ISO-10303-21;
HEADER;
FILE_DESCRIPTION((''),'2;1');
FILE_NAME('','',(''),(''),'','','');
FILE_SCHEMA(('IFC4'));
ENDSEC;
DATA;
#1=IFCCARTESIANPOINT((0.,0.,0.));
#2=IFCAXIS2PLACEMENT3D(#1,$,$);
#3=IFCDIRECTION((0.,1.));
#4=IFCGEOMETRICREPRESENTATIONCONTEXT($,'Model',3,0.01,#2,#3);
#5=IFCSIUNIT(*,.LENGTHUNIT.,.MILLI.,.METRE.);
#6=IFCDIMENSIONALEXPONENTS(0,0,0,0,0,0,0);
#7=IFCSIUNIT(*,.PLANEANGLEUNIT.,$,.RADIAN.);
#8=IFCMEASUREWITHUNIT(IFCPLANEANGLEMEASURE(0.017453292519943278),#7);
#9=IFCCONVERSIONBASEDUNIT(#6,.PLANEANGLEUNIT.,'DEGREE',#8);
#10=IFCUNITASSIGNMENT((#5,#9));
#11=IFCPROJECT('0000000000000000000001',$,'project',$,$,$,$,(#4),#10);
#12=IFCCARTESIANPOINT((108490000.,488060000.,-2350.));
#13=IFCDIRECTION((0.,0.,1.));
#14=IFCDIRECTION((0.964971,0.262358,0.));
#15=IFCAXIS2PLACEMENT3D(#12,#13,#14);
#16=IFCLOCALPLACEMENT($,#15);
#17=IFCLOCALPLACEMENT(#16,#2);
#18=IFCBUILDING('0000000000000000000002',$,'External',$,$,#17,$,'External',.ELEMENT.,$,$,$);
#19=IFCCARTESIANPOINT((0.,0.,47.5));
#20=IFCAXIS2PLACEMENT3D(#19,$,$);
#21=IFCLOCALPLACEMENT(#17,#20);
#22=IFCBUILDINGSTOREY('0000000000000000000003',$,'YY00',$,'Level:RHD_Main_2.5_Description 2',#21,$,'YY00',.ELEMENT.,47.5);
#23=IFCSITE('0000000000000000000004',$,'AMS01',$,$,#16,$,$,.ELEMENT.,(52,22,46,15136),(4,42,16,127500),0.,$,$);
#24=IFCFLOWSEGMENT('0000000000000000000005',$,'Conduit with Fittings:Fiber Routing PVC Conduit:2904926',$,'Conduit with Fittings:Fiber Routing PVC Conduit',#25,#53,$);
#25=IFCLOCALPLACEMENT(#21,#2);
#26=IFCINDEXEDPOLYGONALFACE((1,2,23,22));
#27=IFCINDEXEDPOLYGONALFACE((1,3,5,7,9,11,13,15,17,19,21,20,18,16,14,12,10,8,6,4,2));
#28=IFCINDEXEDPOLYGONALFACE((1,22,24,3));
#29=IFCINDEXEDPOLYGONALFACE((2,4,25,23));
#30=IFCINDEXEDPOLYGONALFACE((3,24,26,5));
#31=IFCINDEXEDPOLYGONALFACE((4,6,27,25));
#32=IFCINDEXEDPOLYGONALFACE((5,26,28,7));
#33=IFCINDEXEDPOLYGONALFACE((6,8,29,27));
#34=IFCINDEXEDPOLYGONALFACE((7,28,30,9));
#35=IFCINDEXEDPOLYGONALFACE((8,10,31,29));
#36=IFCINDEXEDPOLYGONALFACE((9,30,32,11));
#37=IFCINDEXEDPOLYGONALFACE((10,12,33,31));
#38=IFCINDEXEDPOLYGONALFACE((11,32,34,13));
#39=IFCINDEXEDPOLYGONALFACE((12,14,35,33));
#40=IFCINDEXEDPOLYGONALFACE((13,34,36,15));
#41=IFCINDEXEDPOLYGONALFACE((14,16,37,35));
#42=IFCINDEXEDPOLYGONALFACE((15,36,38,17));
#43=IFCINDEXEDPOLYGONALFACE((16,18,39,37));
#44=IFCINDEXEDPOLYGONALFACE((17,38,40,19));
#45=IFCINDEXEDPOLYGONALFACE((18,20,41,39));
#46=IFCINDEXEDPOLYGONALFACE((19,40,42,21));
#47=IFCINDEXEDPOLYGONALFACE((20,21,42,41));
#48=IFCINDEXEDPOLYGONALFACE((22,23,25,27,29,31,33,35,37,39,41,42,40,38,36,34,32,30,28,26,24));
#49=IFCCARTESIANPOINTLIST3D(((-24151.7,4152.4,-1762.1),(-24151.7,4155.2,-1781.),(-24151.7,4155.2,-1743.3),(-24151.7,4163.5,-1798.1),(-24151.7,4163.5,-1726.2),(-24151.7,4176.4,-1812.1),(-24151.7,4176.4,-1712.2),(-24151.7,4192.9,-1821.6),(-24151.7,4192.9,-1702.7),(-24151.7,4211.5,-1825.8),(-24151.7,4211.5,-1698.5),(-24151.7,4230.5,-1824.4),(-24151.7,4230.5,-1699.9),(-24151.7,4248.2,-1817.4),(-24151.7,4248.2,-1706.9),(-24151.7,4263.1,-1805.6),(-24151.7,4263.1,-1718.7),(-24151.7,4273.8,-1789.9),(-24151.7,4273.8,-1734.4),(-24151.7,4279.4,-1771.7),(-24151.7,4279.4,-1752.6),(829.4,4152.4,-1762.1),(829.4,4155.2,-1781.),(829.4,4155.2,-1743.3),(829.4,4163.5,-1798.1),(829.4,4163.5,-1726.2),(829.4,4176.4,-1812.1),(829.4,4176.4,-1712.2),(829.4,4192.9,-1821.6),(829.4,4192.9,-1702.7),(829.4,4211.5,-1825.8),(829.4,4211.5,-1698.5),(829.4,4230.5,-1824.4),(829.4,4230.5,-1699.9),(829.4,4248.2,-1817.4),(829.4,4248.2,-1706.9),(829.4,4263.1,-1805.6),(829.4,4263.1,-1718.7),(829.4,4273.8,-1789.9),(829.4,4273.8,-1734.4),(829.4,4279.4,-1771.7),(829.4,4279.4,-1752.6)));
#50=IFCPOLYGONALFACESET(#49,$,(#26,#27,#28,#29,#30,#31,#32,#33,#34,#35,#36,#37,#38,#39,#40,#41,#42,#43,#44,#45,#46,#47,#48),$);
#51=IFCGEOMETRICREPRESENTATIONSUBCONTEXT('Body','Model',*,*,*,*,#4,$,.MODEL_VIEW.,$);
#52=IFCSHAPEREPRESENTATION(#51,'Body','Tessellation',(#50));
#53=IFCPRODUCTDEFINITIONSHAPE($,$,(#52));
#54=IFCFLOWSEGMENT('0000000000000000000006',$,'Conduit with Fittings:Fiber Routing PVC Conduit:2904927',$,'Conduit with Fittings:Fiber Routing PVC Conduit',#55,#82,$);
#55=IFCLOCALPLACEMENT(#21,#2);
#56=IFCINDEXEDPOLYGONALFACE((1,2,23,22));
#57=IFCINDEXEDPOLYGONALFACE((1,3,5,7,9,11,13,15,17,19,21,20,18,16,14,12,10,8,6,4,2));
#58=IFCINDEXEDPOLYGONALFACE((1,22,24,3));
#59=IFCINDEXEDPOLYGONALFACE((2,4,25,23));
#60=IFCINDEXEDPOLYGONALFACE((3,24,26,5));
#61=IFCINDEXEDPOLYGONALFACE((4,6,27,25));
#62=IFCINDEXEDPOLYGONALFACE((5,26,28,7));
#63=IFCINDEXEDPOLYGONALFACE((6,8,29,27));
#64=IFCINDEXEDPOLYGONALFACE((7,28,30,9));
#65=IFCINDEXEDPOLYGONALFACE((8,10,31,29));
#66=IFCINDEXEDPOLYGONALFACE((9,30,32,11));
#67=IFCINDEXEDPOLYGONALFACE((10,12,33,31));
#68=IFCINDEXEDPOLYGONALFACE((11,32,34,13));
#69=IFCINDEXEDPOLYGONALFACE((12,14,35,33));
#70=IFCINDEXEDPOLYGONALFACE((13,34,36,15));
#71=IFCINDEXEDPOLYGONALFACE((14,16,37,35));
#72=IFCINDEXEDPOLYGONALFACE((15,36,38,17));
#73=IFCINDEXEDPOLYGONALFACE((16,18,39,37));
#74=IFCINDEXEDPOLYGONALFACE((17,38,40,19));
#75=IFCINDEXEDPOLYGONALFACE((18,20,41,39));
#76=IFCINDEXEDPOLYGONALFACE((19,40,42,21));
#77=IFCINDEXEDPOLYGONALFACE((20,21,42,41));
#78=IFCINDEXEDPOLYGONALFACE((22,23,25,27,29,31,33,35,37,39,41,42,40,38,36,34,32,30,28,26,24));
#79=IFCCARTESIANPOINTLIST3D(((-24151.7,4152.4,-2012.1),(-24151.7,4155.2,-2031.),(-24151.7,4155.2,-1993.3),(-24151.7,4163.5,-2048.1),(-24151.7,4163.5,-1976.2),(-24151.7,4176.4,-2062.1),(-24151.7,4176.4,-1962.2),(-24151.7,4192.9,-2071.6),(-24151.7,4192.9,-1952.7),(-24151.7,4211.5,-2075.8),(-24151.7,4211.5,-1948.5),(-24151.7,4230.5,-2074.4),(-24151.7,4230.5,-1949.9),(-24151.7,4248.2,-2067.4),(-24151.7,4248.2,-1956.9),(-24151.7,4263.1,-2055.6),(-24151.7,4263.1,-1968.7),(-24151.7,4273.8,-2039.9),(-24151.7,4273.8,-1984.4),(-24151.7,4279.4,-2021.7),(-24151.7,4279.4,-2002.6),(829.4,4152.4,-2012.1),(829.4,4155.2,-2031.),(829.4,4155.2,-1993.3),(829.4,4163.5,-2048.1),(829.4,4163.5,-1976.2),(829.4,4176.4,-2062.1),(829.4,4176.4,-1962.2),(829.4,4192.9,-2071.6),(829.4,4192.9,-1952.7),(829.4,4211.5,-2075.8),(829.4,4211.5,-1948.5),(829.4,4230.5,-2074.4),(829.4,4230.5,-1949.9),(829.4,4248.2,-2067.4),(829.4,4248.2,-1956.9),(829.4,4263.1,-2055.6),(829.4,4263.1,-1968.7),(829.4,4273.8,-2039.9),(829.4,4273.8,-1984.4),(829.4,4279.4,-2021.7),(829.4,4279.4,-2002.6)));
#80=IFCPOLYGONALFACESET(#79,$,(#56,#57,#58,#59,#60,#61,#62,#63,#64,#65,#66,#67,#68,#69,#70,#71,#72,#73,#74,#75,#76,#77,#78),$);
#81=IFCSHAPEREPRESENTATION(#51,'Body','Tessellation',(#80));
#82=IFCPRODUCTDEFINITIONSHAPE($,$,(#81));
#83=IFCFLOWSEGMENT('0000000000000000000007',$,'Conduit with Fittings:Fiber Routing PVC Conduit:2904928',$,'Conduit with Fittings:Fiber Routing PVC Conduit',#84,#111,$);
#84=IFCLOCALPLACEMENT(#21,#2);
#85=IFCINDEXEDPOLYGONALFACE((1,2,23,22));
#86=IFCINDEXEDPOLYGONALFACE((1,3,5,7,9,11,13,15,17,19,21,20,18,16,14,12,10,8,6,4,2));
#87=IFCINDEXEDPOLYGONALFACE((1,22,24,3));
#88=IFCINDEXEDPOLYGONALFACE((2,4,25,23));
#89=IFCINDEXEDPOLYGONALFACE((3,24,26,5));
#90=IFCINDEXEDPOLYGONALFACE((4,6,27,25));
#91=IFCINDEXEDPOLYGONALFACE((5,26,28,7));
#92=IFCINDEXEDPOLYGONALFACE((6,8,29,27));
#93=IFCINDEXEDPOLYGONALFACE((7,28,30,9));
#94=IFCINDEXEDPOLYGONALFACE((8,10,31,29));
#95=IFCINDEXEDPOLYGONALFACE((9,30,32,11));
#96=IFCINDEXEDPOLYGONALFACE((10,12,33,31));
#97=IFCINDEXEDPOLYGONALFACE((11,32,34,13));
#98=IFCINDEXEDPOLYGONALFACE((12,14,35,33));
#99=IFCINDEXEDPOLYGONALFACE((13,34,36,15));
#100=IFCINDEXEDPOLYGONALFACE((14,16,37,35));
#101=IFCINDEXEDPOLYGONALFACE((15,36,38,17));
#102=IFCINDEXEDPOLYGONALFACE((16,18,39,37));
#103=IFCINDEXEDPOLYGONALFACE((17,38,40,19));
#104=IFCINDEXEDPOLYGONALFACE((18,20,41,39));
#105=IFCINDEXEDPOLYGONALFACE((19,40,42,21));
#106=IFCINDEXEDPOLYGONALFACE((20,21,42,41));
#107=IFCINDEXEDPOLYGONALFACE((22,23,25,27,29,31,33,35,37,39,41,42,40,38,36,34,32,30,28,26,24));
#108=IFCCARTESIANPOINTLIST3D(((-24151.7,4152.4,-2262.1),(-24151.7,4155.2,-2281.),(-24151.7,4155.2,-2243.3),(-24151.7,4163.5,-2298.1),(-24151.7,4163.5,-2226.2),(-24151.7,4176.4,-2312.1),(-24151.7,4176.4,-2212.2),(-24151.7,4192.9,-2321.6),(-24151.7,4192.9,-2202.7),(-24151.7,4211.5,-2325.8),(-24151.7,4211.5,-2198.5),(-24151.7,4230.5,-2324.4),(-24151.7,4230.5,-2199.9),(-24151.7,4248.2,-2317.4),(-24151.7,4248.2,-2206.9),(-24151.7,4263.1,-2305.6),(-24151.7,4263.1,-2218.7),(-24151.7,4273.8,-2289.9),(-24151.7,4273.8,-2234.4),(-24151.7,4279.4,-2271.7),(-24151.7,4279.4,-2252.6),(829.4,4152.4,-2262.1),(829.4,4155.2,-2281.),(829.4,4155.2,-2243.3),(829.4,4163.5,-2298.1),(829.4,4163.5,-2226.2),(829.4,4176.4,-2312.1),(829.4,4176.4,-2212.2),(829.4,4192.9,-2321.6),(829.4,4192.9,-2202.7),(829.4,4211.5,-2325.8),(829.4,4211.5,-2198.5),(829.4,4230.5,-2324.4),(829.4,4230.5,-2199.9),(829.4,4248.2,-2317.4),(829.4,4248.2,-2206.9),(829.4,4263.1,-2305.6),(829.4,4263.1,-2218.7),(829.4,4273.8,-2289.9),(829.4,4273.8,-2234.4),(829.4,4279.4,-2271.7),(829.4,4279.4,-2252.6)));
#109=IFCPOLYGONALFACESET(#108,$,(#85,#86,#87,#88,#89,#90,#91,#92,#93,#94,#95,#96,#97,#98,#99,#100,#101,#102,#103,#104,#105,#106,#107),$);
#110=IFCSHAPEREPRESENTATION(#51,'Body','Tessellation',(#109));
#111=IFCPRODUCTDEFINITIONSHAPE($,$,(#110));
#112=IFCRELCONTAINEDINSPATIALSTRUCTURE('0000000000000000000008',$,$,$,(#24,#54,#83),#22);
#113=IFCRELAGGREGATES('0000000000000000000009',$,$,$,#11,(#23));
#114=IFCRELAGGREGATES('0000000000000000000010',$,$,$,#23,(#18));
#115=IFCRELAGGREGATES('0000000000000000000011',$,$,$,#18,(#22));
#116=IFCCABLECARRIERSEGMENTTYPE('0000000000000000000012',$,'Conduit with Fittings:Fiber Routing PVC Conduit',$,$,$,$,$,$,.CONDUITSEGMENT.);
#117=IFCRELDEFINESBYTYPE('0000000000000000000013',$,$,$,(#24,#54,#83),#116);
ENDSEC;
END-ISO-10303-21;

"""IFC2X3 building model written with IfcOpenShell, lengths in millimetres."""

from ifc_helpers import new_model, entity, si_unit, converted_unit, direction, frame, frame_2d, origin, place, context, subcontext, project, spatial, circle, extrude, type_object, element, save


model = new_model("IFC2X3")

# Units and contexts
model_context = context("Model", 3, precision=0.01, world=origin(), true_north=direction((0.0, 1.0)))
body_context = subcontext(model_context, "Body", "Model", "MODEL_VIEW")
ifc_project = project(units=[si_unit("LENGTHUNIT", "METRE", prefix="MILLI"), converted_unit("PLANEANGLEUNIT", "DEGREE", entity("IfcPlaneAngleMeasure", 0.017453292519943278), si_unit("PLANEANGLEUNIT", "RADIAN"), dimensions=[0, 0, 0, 0, 0, 0, 0])], contexts=[model_context])

# Site, building, storey
site_placement = place(None, frame((108490000.0, 488060000.0, -2350.0), z_axis=(0.0, 0.0, 1.0), x_axis=(0.964971, 0.262358, 0.0)))
site = spatial("IfcSite", under=ifc_project, at=site_placement, Name="AMS01", CompositionType="ELEMENT", RefLatitude=(52, 22, 46, 15136), RefLongitude=(4, 42, 16, 127500), RefElevation=0.0)
building_placement = place(site_placement, origin())
building = spatial("IfcBuilding", under=site, at=building_placement, Name="External", LongName="External", CompositionType="ELEMENT")
storey_placement = place(building_placement, frame((0.0, 0.0, 47.5)))
storey = spatial("IfcBuildingStorey", under=building, at=storey_placement, Name="YY00", ObjectType="Level:RHD_Main_2.5_Description 2", LongName="YY00", CompositionType="ELEMENT", Elevation=47.5)

# Flow segments
cable_carrier_segment_type = type_object("IfcCableCarrierSegmentType", Name="Conduit with Fittings:Fiber Routing PVC Conduit", PredefinedType="CONDUITSEGMENT")
flow_segment_1_placement = place(storey_placement, origin())
element("IfcFlowSegment", 1, at=flow_segment_1_placement, inside=storey, type_object=cable_carrier_segment_type, Name="Conduit with Fittings:Fiber Routing PVC Conduit:2904926", ObjectType="Conduit with Fittings:Fiber Routing PVC Conduit", context=body_context, shape_type="SweptSolid", body=[
    extrude(circle(Radius=63.9, at=frame_2d((0.0, 0.0), x_axis=(1.0, 0.0))), frame((-24151.7, 4216.3, -1762.1), z_axis=(1.0, 0.0, 0.0), x_axis=(0.0, -1.0, 0.0)), (0.0, 0.0, 1.0), 24981.1),
])
flow_segment_2_placement = place(storey_placement, origin())
element("IfcFlowSegment", 2, at=flow_segment_2_placement, inside=storey, type_object=cable_carrier_segment_type, Name="Conduit with Fittings:Fiber Routing PVC Conduit:2904927", ObjectType="Conduit with Fittings:Fiber Routing PVC Conduit", context=body_context, shape_type="SweptSolid", body=[
    extrude(circle(Radius=63.9, at=frame_2d((0.0, 0.0), x_axis=(1.0, 0.0))), frame((-24151.7, 4216.3, -2012.1), z_axis=(1.0, 0.0, 0.0), x_axis=(0.0, -1.0, 0.0)), (0.0, 0.0, 1.0), 24981.1),
])
flow_segment_3_placement = place(storey_placement, origin())
element("IfcFlowSegment", 3, at=flow_segment_3_placement, inside=storey, type_object=cable_carrier_segment_type, Name="Conduit with Fittings:Fiber Routing PVC Conduit:2904928", ObjectType="Conduit with Fittings:Fiber Routing PVC Conduit", context=body_context, shape_type="SweptSolid", body=[
    extrude(circle(Radius=63.9, at=frame_2d((0.0, 0.0), x_axis=(1.0, 0.0))), frame((-24151.7, 4216.3, -2262.1), z_axis=(1.0, 0.0, 0.0), x_axis=(0.0, -1.0, 0.0)), (0.0, 0.0, 1.0), 24981.1),
])

save(model, "model.ifc")
